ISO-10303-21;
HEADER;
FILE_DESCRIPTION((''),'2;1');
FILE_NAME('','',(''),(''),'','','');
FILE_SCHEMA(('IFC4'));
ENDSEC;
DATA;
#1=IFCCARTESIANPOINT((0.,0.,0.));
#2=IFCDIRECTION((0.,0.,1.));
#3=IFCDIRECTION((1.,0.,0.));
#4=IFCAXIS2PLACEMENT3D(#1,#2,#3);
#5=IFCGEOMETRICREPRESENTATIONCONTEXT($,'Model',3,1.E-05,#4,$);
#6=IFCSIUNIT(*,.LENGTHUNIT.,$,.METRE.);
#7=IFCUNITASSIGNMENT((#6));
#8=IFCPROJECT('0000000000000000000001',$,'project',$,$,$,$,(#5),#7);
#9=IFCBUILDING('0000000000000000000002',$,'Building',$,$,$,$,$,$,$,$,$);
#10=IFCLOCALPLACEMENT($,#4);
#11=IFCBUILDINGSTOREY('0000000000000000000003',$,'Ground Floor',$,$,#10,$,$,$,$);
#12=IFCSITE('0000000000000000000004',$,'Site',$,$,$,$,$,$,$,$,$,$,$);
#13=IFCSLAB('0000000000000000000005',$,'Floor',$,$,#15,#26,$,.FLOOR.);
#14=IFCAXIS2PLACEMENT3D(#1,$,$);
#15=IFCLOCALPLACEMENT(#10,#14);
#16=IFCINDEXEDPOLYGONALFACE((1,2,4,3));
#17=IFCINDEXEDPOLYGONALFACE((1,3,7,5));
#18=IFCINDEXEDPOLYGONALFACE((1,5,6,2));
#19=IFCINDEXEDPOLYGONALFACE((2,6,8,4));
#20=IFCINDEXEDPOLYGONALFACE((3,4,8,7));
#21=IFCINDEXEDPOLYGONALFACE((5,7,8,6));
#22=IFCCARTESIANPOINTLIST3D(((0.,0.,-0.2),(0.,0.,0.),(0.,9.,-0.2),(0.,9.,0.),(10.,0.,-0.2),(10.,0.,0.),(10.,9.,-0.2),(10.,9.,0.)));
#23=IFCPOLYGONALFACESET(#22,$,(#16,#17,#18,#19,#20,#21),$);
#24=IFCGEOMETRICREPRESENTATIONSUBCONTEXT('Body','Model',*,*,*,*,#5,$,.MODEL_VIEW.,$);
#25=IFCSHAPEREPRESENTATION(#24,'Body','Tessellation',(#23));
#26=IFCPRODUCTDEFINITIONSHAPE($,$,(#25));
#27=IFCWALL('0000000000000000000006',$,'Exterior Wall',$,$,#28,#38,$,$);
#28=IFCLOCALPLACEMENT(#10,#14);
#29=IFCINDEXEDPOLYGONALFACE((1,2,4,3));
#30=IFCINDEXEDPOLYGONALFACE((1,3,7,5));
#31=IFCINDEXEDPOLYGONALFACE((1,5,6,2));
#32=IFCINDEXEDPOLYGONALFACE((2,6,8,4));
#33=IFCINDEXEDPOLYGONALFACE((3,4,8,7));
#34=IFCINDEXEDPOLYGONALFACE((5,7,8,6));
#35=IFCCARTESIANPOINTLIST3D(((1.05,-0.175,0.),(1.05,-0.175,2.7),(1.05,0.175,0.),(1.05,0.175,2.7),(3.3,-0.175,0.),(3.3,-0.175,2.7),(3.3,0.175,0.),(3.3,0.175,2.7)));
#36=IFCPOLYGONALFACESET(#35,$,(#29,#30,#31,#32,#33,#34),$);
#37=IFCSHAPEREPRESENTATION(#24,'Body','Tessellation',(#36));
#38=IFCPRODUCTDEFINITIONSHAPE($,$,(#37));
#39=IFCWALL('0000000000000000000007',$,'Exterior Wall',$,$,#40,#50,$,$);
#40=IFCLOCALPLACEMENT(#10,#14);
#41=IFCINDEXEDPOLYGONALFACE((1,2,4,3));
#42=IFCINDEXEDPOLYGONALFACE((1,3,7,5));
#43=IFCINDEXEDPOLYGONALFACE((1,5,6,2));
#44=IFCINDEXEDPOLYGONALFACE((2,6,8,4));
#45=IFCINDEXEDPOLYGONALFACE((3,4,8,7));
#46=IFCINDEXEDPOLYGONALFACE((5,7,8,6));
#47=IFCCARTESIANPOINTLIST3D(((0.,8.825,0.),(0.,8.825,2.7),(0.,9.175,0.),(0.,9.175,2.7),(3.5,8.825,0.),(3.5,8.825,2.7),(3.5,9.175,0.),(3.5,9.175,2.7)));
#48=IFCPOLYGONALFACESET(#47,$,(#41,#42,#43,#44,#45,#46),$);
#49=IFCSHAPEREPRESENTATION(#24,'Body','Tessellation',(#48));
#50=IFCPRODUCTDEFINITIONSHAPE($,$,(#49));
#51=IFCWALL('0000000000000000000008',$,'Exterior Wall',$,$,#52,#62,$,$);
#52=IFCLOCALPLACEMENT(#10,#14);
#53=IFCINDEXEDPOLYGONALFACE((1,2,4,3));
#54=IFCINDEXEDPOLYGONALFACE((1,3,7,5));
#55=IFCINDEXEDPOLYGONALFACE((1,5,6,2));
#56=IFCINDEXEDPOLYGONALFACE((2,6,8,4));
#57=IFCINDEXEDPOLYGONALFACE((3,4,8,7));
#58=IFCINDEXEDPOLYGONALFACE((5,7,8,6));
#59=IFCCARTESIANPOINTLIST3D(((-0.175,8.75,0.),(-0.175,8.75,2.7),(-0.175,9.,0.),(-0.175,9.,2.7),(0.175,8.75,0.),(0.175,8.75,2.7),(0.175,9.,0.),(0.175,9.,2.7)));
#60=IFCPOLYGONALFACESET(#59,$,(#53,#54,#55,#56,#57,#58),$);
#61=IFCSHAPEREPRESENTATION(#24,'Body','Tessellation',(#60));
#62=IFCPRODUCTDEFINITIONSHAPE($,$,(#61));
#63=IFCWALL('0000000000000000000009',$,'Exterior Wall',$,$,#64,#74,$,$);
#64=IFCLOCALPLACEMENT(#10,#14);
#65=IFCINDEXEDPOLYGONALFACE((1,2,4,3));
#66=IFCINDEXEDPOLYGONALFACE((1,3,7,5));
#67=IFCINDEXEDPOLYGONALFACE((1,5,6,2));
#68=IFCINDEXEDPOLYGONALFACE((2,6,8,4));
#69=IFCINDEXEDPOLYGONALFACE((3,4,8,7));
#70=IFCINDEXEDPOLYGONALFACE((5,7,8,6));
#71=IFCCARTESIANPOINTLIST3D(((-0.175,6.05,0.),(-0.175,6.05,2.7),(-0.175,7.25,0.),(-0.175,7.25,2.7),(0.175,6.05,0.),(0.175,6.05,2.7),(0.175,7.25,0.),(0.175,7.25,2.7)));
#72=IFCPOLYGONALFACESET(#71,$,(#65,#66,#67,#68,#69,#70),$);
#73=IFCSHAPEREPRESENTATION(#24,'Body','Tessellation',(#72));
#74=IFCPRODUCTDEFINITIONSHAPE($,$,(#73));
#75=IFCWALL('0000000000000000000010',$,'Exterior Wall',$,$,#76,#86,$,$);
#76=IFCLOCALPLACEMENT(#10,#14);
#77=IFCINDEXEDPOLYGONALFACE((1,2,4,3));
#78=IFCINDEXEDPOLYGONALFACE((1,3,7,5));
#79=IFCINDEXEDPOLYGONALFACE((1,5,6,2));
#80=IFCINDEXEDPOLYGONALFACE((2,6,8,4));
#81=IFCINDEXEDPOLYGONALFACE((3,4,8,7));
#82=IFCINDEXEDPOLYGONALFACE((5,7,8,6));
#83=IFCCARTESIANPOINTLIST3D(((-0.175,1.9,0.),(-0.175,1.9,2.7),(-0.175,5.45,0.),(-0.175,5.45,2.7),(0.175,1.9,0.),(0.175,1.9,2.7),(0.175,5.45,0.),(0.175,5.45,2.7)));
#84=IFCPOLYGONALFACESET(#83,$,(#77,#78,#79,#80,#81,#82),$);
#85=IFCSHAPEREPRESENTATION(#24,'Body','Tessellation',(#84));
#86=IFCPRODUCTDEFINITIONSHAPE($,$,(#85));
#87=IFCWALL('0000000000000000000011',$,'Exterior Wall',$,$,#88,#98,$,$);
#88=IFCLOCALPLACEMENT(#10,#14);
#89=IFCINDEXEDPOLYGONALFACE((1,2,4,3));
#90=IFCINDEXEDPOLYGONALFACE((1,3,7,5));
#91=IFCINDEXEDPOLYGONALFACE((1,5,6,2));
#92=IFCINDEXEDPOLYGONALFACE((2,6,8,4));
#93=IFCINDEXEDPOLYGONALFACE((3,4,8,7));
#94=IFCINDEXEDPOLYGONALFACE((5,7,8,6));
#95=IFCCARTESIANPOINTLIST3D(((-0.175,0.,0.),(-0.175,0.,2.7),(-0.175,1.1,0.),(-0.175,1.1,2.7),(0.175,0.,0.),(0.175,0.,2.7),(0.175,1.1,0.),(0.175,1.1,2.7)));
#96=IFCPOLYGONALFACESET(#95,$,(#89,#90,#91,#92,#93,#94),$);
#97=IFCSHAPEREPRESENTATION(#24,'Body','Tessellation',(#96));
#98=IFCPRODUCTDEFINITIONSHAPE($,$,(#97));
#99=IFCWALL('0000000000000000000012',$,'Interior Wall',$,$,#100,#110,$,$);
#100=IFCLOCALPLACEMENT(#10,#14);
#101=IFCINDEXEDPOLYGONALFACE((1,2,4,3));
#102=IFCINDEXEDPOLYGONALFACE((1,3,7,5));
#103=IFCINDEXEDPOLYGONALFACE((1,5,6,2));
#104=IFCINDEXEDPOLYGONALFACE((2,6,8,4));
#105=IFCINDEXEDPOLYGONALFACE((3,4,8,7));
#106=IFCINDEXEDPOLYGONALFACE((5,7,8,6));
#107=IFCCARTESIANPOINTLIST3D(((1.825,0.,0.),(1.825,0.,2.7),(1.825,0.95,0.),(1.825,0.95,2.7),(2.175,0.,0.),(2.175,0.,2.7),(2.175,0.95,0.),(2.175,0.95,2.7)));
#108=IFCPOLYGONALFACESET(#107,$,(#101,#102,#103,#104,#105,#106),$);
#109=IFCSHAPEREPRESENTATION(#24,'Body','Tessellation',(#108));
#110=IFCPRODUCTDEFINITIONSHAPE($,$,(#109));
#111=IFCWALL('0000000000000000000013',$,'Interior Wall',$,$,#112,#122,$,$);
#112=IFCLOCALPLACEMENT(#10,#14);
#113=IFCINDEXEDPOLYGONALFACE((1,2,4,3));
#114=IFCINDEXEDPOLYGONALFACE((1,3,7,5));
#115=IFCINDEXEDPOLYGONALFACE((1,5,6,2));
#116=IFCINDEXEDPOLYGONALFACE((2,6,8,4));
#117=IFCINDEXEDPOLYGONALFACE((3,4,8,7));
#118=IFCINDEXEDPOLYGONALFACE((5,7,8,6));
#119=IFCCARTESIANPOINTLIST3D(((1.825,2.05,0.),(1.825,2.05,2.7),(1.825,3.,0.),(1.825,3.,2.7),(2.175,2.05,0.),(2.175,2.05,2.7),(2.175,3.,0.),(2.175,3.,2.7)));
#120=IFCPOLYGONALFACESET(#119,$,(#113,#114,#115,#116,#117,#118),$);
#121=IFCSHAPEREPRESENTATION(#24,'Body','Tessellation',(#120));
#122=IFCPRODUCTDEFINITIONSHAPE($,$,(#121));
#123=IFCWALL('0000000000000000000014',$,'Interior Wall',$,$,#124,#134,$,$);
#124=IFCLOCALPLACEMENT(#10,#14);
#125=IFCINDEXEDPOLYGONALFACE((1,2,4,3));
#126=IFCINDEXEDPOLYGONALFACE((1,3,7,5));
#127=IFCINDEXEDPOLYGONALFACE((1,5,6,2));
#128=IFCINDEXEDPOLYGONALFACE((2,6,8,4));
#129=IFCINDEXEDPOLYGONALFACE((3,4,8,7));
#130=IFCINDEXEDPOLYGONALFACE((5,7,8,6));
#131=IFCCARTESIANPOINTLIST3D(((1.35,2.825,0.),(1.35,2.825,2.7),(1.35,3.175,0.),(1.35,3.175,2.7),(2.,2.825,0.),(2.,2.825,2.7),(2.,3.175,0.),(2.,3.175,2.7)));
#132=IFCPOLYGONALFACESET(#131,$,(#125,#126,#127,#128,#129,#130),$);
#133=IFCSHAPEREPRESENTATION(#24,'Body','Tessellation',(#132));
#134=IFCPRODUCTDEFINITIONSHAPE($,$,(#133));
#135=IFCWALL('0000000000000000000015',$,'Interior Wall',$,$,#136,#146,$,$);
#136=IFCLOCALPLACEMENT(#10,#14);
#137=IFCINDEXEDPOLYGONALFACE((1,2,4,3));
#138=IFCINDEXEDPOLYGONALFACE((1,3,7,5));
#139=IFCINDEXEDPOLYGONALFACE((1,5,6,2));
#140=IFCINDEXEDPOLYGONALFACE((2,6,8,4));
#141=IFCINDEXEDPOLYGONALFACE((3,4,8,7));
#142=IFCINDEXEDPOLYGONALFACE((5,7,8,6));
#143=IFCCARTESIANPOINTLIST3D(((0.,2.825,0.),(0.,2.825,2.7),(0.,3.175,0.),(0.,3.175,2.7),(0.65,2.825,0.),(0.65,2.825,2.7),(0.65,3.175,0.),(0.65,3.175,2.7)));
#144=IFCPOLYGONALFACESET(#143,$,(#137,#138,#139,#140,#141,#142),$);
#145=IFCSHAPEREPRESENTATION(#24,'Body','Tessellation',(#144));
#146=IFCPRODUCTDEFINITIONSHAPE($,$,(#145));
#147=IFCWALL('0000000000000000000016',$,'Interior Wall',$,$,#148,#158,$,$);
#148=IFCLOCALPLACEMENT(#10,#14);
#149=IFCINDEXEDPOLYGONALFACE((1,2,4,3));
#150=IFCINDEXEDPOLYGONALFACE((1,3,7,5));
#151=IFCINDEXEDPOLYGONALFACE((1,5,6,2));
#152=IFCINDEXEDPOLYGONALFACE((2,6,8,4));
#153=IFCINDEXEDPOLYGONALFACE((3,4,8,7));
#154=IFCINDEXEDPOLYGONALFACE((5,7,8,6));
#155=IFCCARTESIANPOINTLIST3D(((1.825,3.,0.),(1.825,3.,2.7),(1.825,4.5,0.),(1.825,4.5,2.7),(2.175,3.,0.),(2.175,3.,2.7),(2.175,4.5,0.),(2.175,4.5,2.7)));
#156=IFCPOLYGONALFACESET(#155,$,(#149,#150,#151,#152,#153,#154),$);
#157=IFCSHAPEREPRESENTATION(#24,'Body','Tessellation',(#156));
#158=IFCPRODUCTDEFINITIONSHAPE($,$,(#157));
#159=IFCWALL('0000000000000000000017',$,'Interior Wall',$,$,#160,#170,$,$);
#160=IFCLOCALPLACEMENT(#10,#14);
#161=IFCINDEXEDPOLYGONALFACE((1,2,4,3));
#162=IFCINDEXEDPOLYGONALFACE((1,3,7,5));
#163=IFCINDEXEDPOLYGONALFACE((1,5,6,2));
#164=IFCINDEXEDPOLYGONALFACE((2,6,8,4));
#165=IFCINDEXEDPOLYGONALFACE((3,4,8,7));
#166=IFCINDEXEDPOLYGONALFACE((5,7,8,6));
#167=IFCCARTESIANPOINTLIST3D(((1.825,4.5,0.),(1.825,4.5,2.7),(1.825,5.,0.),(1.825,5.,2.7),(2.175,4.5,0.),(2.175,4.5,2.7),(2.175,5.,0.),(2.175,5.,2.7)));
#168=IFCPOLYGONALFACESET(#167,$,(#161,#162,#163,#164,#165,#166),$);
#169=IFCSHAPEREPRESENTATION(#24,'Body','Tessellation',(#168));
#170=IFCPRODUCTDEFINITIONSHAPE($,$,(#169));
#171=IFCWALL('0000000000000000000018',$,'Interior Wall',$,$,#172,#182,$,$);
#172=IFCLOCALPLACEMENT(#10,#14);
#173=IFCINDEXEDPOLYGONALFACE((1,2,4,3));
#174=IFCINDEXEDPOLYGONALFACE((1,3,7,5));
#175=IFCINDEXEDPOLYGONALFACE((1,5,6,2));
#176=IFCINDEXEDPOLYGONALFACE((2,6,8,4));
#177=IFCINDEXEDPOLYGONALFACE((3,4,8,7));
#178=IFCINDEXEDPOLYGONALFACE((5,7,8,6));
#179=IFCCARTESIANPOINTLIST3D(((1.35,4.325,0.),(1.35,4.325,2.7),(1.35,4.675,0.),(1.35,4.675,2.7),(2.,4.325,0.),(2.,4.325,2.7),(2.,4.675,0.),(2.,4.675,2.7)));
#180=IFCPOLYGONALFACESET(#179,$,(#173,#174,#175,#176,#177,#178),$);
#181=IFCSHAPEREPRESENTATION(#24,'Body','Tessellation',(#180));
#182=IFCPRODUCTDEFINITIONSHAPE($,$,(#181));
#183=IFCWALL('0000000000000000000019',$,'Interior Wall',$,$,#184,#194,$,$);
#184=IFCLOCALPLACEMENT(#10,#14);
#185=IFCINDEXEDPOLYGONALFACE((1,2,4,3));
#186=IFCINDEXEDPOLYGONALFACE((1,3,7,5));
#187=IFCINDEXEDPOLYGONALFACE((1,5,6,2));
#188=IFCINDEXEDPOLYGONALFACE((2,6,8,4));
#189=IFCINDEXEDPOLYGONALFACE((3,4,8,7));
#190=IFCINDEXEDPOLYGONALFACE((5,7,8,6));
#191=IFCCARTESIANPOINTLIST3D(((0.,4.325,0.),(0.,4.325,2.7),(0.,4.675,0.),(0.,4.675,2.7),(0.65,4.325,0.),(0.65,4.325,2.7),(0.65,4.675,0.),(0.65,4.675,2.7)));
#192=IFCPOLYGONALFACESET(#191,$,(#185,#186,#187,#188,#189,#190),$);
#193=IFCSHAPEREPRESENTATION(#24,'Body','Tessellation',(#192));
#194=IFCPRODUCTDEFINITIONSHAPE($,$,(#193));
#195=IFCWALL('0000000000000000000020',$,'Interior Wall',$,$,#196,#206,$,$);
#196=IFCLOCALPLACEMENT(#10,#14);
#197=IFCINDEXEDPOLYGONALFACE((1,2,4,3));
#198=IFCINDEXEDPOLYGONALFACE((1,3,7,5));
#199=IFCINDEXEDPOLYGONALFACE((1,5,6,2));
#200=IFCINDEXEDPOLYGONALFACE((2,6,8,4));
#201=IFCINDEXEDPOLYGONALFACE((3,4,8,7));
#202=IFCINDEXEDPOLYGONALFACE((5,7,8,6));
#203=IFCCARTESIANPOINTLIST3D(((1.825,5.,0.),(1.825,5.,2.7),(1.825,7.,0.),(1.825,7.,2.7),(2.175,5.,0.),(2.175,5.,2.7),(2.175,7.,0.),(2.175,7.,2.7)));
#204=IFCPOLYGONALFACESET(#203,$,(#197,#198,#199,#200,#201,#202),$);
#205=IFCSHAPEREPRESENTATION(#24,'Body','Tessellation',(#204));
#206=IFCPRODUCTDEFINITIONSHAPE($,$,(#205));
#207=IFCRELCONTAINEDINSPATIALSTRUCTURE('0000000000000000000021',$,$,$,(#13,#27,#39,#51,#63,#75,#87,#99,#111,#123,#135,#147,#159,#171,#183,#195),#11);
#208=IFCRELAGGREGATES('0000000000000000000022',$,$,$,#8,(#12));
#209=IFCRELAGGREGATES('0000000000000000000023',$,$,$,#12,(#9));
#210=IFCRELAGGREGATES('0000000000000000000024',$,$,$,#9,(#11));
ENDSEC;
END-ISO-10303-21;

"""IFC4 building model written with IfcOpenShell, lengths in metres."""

from ifc_helpers import new_model, si_unit, frame, origin_with_axes, place, context, subcontext, project, spatial, indexed_curve, outline, extrude, element, save


model = new_model("IFC4")

# Units and contexts
model_context = context("Model", 3, precision=1e-05, world=origin_with_axes())
body_context = subcontext(model_context, "Body", "Model", "MODEL_VIEW")
ifc_project = project(units=[si_unit("LENGTHUNIT", "METRE")], contexts=[model_context])

# Site, building, storey
site = spatial("IfcSite", under=ifc_project, Name="Site")
building = spatial("IfcBuilding", under=site, Name="Building")
storey_placement = place(None, origin_with_axes())
storey = spatial("IfcBuildingStorey", under=building, at=storey_placement, Name="Ground Floor")

# Slab
slab_placement = place(storey_placement, frame((0.0, 0.0, -0.2), z_axis=(0.0, 0.0, 1.0), x_axis=(1.0, 0.0, 0.0)))
element("IfcSlab", 1, at=slab_placement, inside=storey, Name="Floor", PredefinedType="FLOOR", context=body_context, shape_type="SweptSolid", body=[
    extrude(outline(indexed_curve([(0.0, 0.0), (10.0, 0.0), (10.0, 9.0), (0.0, 9.0)])), None, (0.0, 0.0, 1.0), 0.2),
])

# Walls
wall_1_placement = place(storey_placement, frame((1.05, 0.0, 0.0), z_axis=(0.0, 0.0, 1.0), x_axis=(1.0, 0.0, 0.0)))
element("IfcWall", 2, at=wall_1_placement, inside=storey, Name="Exterior Wall", context=body_context, shape_type="SweptSolid", body=[
    extrude(outline(indexed_curve([(0.0, 0.0), (0.0, 0.35), (2.25, 0.35), (2.25, 0.0), (0.0, 0.0)], self_intersect=False)), frame((0.0, -0.175, 0.0), z_axis=(0.0, 0.0, 1.0), x_axis=(1.0, 0.0, 0.0)), (0.0, 0.0, 1.0), 2.7),
])
wall_2_placement = place(storey_placement, frame((3.5, 9.0, 0.0), z_axis=(0.0, 0.0, 1.0), x_axis=(-1.0, 0.0, 0.0)))
element("IfcWall", 3, at=wall_2_placement, inside=storey, Name="Exterior Wall", context=body_context, shape_type="SweptSolid", body=[
    extrude(outline(indexed_curve([(0.0, 0.0), (0.0, 0.35), (3.5, 0.35), (3.5, 0.0), (0.0, 0.0)], self_intersect=False)), frame((0.0, -0.175, 0.0), z_axis=(0.0, 0.0, 1.0), x_axis=(1.0, 0.0, 0.0)), (0.0, 0.0, 1.0), 2.7),
])
wall_3_placement = place(storey_placement, frame((0.0, 9.0, 0.0), z_axis=(0.0, 0.0, 1.0), x_axis=(0.0, -1.0, 0.0)))
element("IfcWall", 4, at=wall_3_placement, inside=storey, Name="Exterior Wall", context=body_context, shape_type="SweptSolid", body=[
    extrude(outline(indexed_curve([(0.0, 0.0), (0.0, 0.35), (0.25, 0.35), (0.25, 0.0), (0.0, 0.0)], self_intersect=False)), frame((0.0, -0.175, 0.0), z_axis=(0.0, 0.0, 1.0), x_axis=(1.0, 0.0, 0.0)), (0.0, 0.0, 1.0), 2.7),
])
wall_4_placement = place(storey_placement, frame((0.0, 7.25, 0.0), z_axis=(0.0, 0.0, 1.0), x_axis=(0.0, -1.0, 0.0)))
element("IfcWall", 5, at=wall_4_placement, inside=storey, Name="Exterior Wall", context=body_context, shape_type="SweptSolid", body=[
    extrude(outline(indexed_curve([(0.0, 0.0), (0.0, 0.35), (1.2, 0.35), (1.2, 0.0), (0.0, 0.0)], self_intersect=False)), frame((0.0, -0.175, 0.0), z_axis=(0.0, 0.0, 1.0), x_axis=(1.0, 0.0, 0.0)), (0.0, 0.0, 1.0), 2.7),
])
wall_5_placement = place(storey_placement, frame((0.0, 5.45, 0.0), z_axis=(0.0, 0.0, 1.0), x_axis=(0.0, -1.0, 0.0)))
element("IfcWall", 6, at=wall_5_placement, inside=storey, Name="Exterior Wall", context=body_context, shape_type="SweptSolid", body=[
    extrude(outline(indexed_curve([(0.0, 0.0), (0.0, 0.35), (3.55, 0.35), (3.55, 0.0), (0.0, 0.0)], self_intersect=False)), frame((0.0, -0.175, 0.0), z_axis=(0.0, 0.0, 1.0), x_axis=(1.0, 0.0, 0.0)), (0.0, 0.0, 1.0), 2.7),
])
wall_6_placement = place(storey_placement, frame((0.0, 1.1, 0.0), z_axis=(0.0, 0.0, 1.0), x_axis=(0.0, -1.0, 0.0)))
element("IfcWall", 7, at=wall_6_placement, inside=storey, Name="Exterior Wall", context=body_context, shape_type="SweptSolid", body=[
    extrude(outline(indexed_curve([(0.0, 0.0), (0.0, 0.35), (1.1, 0.35), (1.1, 0.0), (0.0, 0.0)], self_intersect=False)), frame((0.0, -0.175, 0.0), z_axis=(0.0, 0.0, 1.0), x_axis=(1.0, 0.0, 0.0)), (0.0, 0.0, 1.0), 2.7),
])
wall_7_placement = place(storey_placement, frame((2.0, 0.0, 0.0), z_axis=(0.0, 0.0, 1.0), x_axis=(0.0, 1.0, 0.0)))
element("IfcWall", 8, at=wall_7_placement, inside=storey, Name="Interior Wall", context=body_context, shape_type="SweptSolid", body=[
    extrude(outline(indexed_curve([(0.0, 0.0), (0.0, 0.35), (0.95, 0.35), (0.95, 0.0), (0.0, 0.0)], self_intersect=False)), frame((0.0, -0.175, 0.0), z_axis=(0.0, 0.0, 1.0), x_axis=(1.0, 0.0, 0.0)), (0.0, 0.0, 1.0), 2.7),
])
wall_8_placement = place(storey_placement, frame((2.0, 2.05, 0.0), z_axis=(0.0, 0.0, 1.0), x_axis=(0.0, 1.0, 0.0)))
element("IfcWall", 9, at=wall_8_placement, inside=storey, Name="Interior Wall", context=body_context, shape_type="SweptSolid", body=[
    extrude(outline(indexed_curve([(0.0, 0.0), (0.0, 0.35), (0.95, 0.35), (0.95, 0.0), (0.0, 0.0)], self_intersect=False)), frame((0.0, -0.175, 0.0), z_axis=(0.0, 0.0, 1.0), x_axis=(1.0, 0.0, 0.0)), (0.0, 0.0, 1.0), 2.7),
])
for number, where, z_axis, x_axis, name in (
    (10, (2.0, 3.0, 0.0), (0.0, 0.0, 1.0), (-1.0, 0.0, 0.0), "Interior Wall"),
    (11, (0.65, 3.0, 0.0), (0.0, 0.0, 1.0), (-1.0, 0.0, 0.0), "Interior Wall"),
):
    element("IfcWall", number, at=place(storey_placement, frame(where, z_axis=z_axis, x_axis=x_axis)), inside=storey, Name=name, context=body_context, shape_type="SweptSolid", body=[
        extrude(outline(indexed_curve([(0.0, 0.0), (0.0, 0.35), (0.65, 0.35), (0.65, 0.0), (0.0, 0.0)], self_intersect=False)), frame((0.0, -0.175, 0.0), z_axis=(0.0, 0.0, 1.0), x_axis=(1.0, 0.0, 0.0)), (0.0, 0.0, 1.0), 2.7),
    ])
wall_9_placement = place(storey_placement, frame((2.0, 4.5, 0.0), z_axis=(0.0, 0.0, 1.0), x_axis=(0.0, -1.0, 0.0)))
element("IfcWall", 12, at=wall_9_placement, inside=storey, Name="Interior Wall", context=body_context, shape_type="SweptSolid", body=[
    extrude(outline(indexed_curve([(0.0, 0.0), (0.0, 0.35), (1.5, 0.35), (1.5, 0.0), (0.0, 0.0)], self_intersect=False)), frame((0.0, -0.175, 0.0), z_axis=(0.0, 0.0, 1.0), x_axis=(1.0, 0.0, 0.0)), (0.0, 0.0, 1.0), 2.7),
])
wall_10_placement = place(storey_placement, frame((2.0, 5.0, 0.0), z_axis=(0.0, 0.0, 1.0), x_axis=(0.0, -1.0, 0.0)))
element("IfcWall", 13, at=wall_10_placement, inside=storey, Name="Interior Wall", context=body_context, shape_type="SweptSolid", body=[
    extrude(outline(indexed_curve([(0.0, 0.0), (0.0, 0.35), (0.5, 0.35), (0.5, 0.0), (0.0, 0.0)], self_intersect=False)), frame((0.0, -0.175, 0.0), z_axis=(0.0, 0.0, 1.0), x_axis=(1.0, 0.0, 0.0)), (0.0, 0.0, 1.0), 2.7),
])
for number, where, z_axis, x_axis, name in (
    (14, (2.0, 4.5, 0.0), (0.0, 0.0, 1.0), (-1.0, 0.0, 0.0), "Interior Wall"),
    (15, (0.65, 4.5, 0.0), (0.0, 0.0, 1.0), (-1.0, 0.0, 0.0), "Interior Wall"),
):
    element("IfcWall", number, at=place(storey_placement, frame(where, z_axis=z_axis, x_axis=x_axis)), inside=storey, Name=name, context=body_context, shape_type="SweptSolid", body=[
        extrude(outline(indexed_curve([(0.0, 0.0), (0.0, 0.35), (0.65, 0.35), (0.65, 0.0), (0.0, 0.0)], self_intersect=False)), frame((0.0, -0.175, 0.0), z_axis=(0.0, 0.0, 1.0), x_axis=(1.0, 0.0, 0.0)), (0.0, 0.0, 1.0), 2.7),
    ])
wall_11_placement = place(storey_placement, frame((2.0, 5.0, 0.0), z_axis=(0.0, 0.0, 1.0), x_axis=(0.0, 1.0, 0.0)))
element("IfcWall", 16, at=wall_11_placement, inside=storey, Name="Interior Wall", context=body_context, shape_type="SweptSolid", body=[
    extrude(outline(indexed_curve([(0.0, 0.0), (0.0, 0.35), (2.0, 0.35), (2.0, 0.0), (0.0, 0.0)], self_intersect=False)), frame((0.0, -0.175, 0.0), z_axis=(0.0, 0.0, 1.0), x_axis=(1.0, 0.0, 0.0)), (0.0, 0.0, 1.0), 2.7),
])

save(model, "model.ifc")
